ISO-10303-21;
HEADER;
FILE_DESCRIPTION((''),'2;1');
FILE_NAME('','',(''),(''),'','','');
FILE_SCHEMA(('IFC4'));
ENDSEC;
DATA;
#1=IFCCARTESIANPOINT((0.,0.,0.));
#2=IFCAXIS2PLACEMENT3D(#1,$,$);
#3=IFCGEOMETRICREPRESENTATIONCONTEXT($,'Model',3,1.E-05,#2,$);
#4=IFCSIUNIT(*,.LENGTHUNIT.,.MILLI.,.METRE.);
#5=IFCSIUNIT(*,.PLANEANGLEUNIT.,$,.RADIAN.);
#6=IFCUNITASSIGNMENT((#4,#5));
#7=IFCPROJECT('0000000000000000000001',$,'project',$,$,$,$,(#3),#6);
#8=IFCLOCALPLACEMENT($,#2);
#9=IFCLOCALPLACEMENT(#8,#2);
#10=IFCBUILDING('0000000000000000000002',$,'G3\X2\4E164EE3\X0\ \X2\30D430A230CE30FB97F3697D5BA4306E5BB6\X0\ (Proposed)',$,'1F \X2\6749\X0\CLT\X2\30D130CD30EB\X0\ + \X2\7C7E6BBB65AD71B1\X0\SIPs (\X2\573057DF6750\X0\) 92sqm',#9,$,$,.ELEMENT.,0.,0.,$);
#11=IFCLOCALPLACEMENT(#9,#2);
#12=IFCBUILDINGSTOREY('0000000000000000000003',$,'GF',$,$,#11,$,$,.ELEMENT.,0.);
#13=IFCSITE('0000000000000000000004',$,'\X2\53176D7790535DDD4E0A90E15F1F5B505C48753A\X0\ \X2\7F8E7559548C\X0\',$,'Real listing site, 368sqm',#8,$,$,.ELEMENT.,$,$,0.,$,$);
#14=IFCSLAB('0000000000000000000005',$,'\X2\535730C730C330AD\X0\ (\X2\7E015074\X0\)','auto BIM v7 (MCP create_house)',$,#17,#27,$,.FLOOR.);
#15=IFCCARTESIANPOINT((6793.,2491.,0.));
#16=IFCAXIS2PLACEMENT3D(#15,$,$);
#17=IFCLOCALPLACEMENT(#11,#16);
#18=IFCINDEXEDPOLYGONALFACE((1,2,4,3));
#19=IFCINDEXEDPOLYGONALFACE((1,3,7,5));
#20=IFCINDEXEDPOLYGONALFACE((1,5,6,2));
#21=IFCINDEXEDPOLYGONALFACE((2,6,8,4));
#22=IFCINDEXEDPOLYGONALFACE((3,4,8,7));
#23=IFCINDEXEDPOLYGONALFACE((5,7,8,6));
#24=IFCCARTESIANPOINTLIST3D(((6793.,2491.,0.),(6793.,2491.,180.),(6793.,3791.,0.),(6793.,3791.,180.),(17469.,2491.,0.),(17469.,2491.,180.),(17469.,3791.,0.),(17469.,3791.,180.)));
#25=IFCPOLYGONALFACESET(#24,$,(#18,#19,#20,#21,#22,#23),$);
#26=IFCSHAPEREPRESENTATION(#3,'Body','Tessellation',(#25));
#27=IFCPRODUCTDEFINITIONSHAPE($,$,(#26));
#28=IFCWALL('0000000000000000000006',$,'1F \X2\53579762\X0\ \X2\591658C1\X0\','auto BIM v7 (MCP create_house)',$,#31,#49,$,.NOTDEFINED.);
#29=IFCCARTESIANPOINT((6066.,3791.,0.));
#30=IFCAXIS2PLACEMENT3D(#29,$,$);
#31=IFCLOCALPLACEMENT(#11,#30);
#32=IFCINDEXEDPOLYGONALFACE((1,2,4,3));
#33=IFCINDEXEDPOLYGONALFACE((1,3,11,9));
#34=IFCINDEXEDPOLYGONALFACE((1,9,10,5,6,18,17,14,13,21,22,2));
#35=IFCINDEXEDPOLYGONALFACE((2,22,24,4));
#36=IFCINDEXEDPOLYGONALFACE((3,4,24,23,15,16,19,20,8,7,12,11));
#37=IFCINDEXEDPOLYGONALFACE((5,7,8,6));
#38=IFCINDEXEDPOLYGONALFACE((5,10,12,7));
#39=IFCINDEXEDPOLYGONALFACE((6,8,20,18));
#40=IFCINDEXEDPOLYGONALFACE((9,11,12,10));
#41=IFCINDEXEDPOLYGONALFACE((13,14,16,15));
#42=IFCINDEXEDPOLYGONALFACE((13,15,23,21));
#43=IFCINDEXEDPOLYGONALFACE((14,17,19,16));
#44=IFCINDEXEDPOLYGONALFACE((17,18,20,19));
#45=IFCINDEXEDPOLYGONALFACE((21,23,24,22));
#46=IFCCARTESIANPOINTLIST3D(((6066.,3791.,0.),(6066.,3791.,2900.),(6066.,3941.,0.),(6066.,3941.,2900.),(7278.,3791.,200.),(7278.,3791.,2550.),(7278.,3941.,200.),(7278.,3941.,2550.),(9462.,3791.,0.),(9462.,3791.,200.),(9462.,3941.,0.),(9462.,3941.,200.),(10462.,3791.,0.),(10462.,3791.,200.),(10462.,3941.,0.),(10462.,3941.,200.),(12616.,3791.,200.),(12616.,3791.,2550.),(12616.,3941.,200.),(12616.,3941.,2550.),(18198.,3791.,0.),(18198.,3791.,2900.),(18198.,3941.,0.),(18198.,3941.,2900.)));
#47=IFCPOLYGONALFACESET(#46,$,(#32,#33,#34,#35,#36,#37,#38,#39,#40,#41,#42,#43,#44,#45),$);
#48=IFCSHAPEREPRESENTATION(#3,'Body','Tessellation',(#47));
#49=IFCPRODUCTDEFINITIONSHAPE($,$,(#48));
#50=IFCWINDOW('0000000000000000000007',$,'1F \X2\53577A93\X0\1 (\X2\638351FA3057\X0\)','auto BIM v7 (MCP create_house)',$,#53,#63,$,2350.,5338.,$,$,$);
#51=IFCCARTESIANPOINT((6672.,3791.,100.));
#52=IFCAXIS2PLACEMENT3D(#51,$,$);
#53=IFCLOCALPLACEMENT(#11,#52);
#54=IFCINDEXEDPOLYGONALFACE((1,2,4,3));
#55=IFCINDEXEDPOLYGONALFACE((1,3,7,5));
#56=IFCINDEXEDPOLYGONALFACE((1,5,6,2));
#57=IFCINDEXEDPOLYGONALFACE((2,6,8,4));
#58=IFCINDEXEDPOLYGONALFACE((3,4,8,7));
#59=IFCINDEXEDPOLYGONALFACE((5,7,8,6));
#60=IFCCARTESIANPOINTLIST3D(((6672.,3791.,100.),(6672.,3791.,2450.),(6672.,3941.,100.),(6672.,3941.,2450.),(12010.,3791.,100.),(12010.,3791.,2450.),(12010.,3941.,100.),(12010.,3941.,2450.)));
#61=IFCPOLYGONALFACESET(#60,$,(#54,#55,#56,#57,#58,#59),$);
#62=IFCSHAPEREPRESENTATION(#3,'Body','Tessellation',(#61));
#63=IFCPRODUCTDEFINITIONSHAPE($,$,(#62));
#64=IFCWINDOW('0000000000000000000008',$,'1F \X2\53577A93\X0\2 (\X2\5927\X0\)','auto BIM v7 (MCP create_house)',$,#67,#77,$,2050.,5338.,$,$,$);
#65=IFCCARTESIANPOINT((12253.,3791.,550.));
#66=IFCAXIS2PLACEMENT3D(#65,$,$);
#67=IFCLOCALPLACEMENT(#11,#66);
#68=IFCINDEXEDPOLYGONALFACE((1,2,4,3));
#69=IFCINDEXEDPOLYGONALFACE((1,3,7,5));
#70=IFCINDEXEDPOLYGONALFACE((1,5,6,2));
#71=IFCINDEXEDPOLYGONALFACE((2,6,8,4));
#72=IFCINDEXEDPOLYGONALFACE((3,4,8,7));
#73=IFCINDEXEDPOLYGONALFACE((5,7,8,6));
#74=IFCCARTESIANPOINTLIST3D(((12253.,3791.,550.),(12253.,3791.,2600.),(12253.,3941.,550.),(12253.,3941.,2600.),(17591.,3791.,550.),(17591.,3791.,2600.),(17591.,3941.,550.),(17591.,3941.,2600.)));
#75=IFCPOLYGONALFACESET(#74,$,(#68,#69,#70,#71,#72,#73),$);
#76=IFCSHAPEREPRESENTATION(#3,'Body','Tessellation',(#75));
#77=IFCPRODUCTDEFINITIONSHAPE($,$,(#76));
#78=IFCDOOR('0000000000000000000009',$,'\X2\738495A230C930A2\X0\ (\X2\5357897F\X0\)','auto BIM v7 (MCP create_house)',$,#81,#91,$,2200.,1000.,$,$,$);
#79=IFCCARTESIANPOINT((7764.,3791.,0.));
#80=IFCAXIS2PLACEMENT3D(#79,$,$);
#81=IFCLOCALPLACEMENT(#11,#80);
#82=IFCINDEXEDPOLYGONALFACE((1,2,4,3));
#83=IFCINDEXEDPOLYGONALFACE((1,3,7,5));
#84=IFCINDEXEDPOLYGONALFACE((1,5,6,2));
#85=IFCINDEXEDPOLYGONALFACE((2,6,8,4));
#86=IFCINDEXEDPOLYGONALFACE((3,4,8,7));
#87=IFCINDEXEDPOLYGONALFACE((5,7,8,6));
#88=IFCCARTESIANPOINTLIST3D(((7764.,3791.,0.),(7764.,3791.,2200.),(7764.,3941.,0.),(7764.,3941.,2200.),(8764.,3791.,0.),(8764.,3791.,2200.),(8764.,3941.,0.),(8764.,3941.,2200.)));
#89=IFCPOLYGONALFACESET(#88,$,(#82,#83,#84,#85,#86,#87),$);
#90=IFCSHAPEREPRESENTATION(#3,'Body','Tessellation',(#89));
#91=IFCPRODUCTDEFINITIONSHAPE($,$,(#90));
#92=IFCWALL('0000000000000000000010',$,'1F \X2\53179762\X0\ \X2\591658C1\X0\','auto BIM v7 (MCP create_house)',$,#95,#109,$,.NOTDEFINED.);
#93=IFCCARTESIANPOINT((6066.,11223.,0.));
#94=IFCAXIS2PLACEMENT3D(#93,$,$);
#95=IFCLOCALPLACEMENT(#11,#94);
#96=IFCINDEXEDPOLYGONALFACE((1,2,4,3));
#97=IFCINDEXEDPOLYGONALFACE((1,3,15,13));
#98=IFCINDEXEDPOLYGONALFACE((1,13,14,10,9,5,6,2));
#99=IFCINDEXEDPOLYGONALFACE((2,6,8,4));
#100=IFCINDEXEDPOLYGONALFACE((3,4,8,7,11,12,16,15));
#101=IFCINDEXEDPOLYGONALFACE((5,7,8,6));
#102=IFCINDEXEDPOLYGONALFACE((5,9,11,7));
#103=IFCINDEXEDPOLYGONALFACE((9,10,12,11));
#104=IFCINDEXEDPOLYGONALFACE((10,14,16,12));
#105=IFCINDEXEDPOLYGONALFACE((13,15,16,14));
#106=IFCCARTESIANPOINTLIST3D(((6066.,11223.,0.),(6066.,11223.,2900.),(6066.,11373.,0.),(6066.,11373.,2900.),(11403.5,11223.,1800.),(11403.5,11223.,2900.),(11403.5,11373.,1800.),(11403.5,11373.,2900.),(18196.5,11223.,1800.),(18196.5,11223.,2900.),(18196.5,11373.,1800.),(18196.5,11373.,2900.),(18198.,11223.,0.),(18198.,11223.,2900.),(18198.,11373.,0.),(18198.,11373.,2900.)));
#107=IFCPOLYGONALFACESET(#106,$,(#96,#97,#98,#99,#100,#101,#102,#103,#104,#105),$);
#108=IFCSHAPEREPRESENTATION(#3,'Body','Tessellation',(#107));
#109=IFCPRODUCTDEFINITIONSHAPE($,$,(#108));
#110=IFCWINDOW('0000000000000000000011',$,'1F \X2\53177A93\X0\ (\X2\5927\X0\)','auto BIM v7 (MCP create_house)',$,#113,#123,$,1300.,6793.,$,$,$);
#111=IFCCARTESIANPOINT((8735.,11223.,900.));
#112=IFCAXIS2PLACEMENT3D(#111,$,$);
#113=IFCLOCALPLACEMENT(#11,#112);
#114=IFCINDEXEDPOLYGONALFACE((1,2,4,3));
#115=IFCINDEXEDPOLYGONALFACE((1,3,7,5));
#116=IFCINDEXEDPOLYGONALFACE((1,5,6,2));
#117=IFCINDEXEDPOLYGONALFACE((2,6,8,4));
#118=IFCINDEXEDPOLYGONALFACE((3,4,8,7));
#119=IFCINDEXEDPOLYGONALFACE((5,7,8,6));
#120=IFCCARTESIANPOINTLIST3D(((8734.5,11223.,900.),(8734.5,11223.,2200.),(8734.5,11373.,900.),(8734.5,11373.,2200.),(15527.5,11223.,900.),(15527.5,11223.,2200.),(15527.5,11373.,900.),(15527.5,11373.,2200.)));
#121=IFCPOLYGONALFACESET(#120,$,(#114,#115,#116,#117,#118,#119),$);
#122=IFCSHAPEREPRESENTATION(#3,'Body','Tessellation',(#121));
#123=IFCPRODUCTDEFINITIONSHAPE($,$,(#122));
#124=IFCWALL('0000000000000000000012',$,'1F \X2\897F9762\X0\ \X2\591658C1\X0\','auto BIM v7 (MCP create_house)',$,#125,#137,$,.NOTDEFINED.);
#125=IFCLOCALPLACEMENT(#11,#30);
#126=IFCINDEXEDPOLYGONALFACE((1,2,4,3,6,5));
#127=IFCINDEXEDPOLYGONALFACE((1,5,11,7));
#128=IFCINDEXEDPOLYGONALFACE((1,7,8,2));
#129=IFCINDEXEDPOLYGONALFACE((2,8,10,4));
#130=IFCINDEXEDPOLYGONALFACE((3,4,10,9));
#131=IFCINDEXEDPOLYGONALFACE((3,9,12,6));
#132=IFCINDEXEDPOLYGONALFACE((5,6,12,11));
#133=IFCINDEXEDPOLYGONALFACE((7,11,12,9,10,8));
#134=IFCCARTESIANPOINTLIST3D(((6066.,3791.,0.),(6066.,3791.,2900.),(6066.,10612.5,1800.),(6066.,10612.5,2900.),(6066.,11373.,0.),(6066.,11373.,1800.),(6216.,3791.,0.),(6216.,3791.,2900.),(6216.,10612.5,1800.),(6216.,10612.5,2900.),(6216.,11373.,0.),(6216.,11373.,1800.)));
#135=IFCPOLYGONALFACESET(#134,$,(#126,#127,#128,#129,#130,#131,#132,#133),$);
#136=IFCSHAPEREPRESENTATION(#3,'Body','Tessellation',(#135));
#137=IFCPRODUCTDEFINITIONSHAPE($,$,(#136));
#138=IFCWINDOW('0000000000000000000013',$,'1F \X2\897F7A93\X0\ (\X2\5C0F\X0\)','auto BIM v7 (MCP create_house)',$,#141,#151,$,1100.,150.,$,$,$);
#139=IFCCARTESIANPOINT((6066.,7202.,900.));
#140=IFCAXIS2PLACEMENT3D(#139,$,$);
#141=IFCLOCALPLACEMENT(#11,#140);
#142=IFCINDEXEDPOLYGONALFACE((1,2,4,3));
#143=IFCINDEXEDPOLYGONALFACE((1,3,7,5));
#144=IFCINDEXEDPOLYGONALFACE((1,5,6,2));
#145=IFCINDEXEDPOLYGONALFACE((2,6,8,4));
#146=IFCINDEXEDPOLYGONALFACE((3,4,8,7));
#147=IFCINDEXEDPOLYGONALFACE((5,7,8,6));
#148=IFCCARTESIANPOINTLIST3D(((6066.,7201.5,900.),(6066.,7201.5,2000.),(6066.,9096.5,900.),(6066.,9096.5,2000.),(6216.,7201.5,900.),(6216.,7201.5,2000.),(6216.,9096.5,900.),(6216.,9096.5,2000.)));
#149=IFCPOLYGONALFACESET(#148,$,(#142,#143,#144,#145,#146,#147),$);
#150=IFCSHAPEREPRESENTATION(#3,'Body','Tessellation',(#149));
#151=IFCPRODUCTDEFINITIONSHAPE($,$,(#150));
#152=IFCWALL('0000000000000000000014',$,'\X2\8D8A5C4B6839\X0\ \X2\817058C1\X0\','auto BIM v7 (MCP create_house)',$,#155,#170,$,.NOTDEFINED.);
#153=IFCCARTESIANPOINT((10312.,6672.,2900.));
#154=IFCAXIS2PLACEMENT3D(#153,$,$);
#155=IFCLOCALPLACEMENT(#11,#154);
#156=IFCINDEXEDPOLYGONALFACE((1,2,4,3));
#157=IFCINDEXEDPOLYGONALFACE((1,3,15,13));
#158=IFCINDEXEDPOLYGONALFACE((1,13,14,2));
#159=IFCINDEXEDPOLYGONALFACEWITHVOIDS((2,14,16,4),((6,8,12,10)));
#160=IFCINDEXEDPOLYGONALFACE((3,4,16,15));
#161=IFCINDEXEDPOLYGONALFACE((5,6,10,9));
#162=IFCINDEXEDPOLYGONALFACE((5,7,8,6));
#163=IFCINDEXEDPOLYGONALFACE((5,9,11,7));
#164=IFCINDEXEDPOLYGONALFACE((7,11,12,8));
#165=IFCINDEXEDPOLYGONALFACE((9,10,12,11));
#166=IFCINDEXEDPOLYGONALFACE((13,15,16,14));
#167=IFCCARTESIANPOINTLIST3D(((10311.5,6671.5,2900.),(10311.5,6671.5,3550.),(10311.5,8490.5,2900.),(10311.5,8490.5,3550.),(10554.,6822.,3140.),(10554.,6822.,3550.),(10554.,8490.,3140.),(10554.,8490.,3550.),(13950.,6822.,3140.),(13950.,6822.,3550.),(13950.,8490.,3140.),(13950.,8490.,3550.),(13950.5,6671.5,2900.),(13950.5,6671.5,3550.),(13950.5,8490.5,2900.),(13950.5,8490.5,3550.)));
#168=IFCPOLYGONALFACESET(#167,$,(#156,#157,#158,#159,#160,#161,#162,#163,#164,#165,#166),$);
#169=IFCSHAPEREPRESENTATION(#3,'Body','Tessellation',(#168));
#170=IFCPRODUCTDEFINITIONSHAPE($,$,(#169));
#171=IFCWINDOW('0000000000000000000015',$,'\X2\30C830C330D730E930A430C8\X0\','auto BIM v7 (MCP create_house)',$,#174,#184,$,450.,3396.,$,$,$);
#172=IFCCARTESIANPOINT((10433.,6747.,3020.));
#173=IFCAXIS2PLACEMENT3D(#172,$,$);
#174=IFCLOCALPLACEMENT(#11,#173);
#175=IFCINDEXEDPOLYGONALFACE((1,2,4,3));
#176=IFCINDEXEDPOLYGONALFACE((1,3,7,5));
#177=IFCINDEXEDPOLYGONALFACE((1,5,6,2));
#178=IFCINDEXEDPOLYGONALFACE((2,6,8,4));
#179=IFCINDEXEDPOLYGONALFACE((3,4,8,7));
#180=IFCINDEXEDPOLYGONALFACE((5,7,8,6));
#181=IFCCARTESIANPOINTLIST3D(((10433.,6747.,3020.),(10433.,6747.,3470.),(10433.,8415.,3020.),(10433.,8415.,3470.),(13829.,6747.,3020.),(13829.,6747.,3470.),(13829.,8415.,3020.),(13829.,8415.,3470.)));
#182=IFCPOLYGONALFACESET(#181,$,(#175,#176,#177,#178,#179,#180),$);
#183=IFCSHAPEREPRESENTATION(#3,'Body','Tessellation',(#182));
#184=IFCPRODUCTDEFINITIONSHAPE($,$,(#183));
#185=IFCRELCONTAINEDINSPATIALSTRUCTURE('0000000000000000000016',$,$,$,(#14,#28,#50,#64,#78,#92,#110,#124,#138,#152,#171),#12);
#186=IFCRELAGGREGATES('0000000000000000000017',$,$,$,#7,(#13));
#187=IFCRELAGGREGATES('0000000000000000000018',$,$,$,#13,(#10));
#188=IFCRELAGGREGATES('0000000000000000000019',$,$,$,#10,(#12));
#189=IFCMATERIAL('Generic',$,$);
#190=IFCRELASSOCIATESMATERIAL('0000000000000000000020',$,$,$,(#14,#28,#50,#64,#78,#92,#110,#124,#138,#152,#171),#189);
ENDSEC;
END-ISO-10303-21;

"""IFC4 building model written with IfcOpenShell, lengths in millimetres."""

from ifc_helpers import new_model, si_unit, frame, frame_2d, origin, place, context, project, spatial, rectangle, extrude, material, element, fill, save


model = new_model("IFC4")

# Units and contexts
model_context = context("Model", 3, precision=1e-05, world=origin())
ifc_project = project(units=[si_unit("LENGTHUNIT", "METRE", prefix="MILLI"), si_unit("PLANEANGLEUNIT", "RADIAN")], contexts=[model_context])

# Site, building, storey
site_placement = place(None, origin())
site = spatial("IfcSite", under=ifc_project, at=site_placement, Name="北海道川上郡弟子屈町 美留和", ObjectType="Real listing site, 368sqm", CompositionType="ELEMENT", RefElevation=0.0)
building_placement = place(site_placement, origin())
building = spatial("IfcBuilding", under=site, at=building_placement, Name="G3世代 ピアノ・音楽室の家 (Proposed)", ObjectType="1F 杉CLTパネル + 籾殻断熱SIPs (地域材) 92sqm", CompositionType="ELEMENT", ElevationOfRefHeight=0.0, ElevationOfTerrain=0.0)
storey_placement = place(building_placement, origin())
storey = spatial("IfcBuildingStorey", under=building, at=storey_placement, Name="GF", CompositionType="ELEMENT", Elevation=0.0)

# Slab
ifc_material = material(Name="Generic")
slab_1_placement = place(storey_placement, frame((6793.0, 2491.0, 0.0)))
element("IfcSlab", 1, at=slab_1_placement, inside=storey, material=ifc_material, Name="南デッキ (縁側)", Description="auto BIM v7 (MCP create_house)", PredefinedType="FLOOR", context=model_context, shape_type="SweptSolid", body=[
    extrude(rectangle(XDim=10676.0, YDim=1300.0, at=frame_2d((5338.0, 650.0))), frame((6793.0, 2491.0, 0.0)), (0.0, 0.0, 1.0), 180.0),
])

# Wall, openings, windows, door
wall_1_placement = place(storey_placement, frame((6066.0, 3791.0, 0.0)))
wall_1 = element("IfcWall", 2, at=wall_1_placement, inside=storey, material=ifc_material, Name="1F 南面 外壁", Description="auto BIM v7 (MCP create_house)", PredefinedType="NOTDEFINED", context=model_context, shape_type="SweptSolid", body=[
    extrude(rectangle(XDim=12132.0, YDim=150.0, at=frame_2d((6066.0, 75.0))), frame((6066.0, 3791.0, 0.0)), (0.0, 0.0, 1.0), 2900.0),
])
opening_1_placement = place(storey_placement, frame((6672.0, 3791.0, 100.0)))
opening_1 = element("IfcOpeningElement", 3, at=opening_1_placement, cuts=wall_1, PredefinedType="NOTDEFINED", context=model_context, shape_type="SweptSolid", body=[
    extrude(rectangle(XDim=5338.0, YDim=150.0, at=frame_2d((2669.0, 75.0))), frame((6672.0, 3791.0, 100.0)), (0.0, 0.0, 1.0), 2350.0),
])
opening_2_placement = place(storey_placement, frame((12253.0, 3791.0, 550.0)))
opening_2 = element("IfcOpeningElement", 4, at=opening_2_placement, cuts=wall_1, PredefinedType="NOTDEFINED", context=model_context, shape_type="SweptSolid", body=[
    extrude(rectangle(XDim=5338.0, YDim=150.0, at=frame_2d((2669.0, 75.0))), frame((12253.0, 3791.0, 550.0)), (0.0, 0.0, 1.0), 2050.0),
])
opening_3_placement = place(storey_placement, frame((7764.0, 3791.0, 0.0)))
opening_3 = element("IfcOpeningElement", 5, at=opening_3_placement, cuts=wall_1, PredefinedType="NOTDEFINED", context=model_context, shape_type="SweptSolid", body=[
    extrude(rectangle(XDim=1000.0, YDim=150.0, at=frame_2d((500.0, 75.0))), frame((7764.0, 3791.0, 0.0)), (0.0, 0.0, 1.0), 2200.0),
])
window_1_placement = place(storey_placement, frame((6672.0, 3791.0, 100.0)))
window_1 = element("IfcWindow", 6, at=window_1_placement, inside=storey, material=ifc_material, Name="1F 南窓1 (掃出し)", Description="auto BIM v7 (MCP create_house)", OverallHeight=2350.0, OverallWidth=5338.0, context=model_context, shape_type="SweptSolid", body=[
    extrude(rectangle(XDim=5338.0, YDim=150.0, at=frame_2d((2669.0, 75.0))), frame((6672.0, 3791.0, 100.0)), (0.0, 0.0, 1.0), 2350.0),
])
fill(opening_1, window_1)
window_2_placement = place(storey_placement, frame((12253.0, 3791.0, 550.0)))
window_2 = element("IfcWindow", 7, at=window_2_placement, inside=storey, material=ifc_material, Name="1F 南窓2 (大)", Description="auto BIM v7 (MCP create_house)", OverallHeight=2050.0, OverallWidth=5338.0, context=model_context, shape_type="SweptSolid", body=[
    extrude(rectangle(XDim=5338.0, YDim=150.0, at=frame_2d((2669.0, 75.0))), frame((12253.0, 3791.0, 550.0)), (0.0, 0.0, 1.0), 2050.0),
])
fill(opening_2, window_2)
door_placement = place(storey_placement, frame((7764.0, 3791.0, 0.0)))
door = element("IfcDoor", 8, at=door_placement, inside=storey, material=ifc_material, Name="玄関ドア (南西)", Description="auto BIM v7 (MCP create_house)", OverallHeight=2200.0, OverallWidth=1000.0, context=model_context, shape_type="SweptSolid", body=[
    extrude(rectangle(XDim=1000.0, YDim=150.0, at=frame_2d((500.0, 75.0))), frame((7764.0, 3791.0, 0.0)), (0.0, 0.0, 1.0), 2200.0),
])
fill(opening_3, door)

# Walls, openings, windows
wall_2_placement = place(storey_placement, frame((6066.0, 11223.0, 0.0)))
wall_2 = element("IfcWall", 9, at=wall_2_placement, inside=storey, material=ifc_material, Name="1F 北面 外壁", Description="auto BIM v7 (MCP create_house)", PredefinedType="NOTDEFINED", context=model_context, shape_type="SweptSolid", body=[
    extrude(rectangle(XDim=12132.0, YDim=150.0, at=frame_2d((6066.0, 75.0))), frame((6066.0, 11223.0, 0.0)), (0.0, 0.0, 1.0), 2900.0),
])
opening_4_placement = place(storey_placement, frame((8735.0, 11223.0, 900.0)))
opening_4 = element("IfcOpeningElement", 10, at=opening_4_placement, cuts=wall_2, PredefinedType="NOTDEFINED", context=model_context, shape_type="SweptSolid", body=[
    extrude(rectangle(XDim=6793.0, YDim=150.0, at=frame_2d((3396.0, 75.0))), frame((8735.0, 11223.0, 900.0)), (0.0, 0.0, 1.0), 1300.0),
])
window_3_placement = place(storey_placement, frame((8735.0, 11223.0, 900.0)))
window_3 = element("IfcWindow", 11, at=window_3_placement, inside=storey, material=ifc_material, Name="1F 北窓 (大)", Description="auto BIM v7 (MCP create_house)", OverallHeight=1300.0, OverallWidth=6793.0, context=model_context, shape_type="SweptSolid", body=[
    extrude(rectangle(XDim=6793.0, YDim=150.0, at=frame_2d((3396.0, 75.0))), frame((8735.0, 11223.0, 900.0)), (0.0, 0.0, 1.0), 1300.0),
])
fill(opening_4, window_3)
wall_3_placement = place(storey_placement, frame((6066.0, 3791.0, 0.0)))
wall_3 = element("IfcWall", 12, at=wall_3_placement, inside=storey, material=ifc_material, Name="1F 西面 外壁", Description="auto BIM v7 (MCP create_house)", PredefinedType="NOTDEFINED", context=model_context, shape_type="SweptSolid", body=[
    extrude(rectangle(XDim=150.0, YDim=7582.0, at=frame_2d((75.0, 3791.0))), frame((6066.0, 3791.0, 0.0)), (0.0, 0.0, 1.0), 2900.0),
])
opening_5_placement = place(storey_placement, frame((6066.0, 7202.0, 900.0)))
opening_5 = element("IfcOpeningElement", 13, at=opening_5_placement, cuts=wall_3, PredefinedType="NOTDEFINED", context=model_context, shape_type="SweptSolid", body=[
    extrude(rectangle(XDim=150.0, YDim=1895.0, at=frame_2d((75.0, 947.0))), frame((6066.0, 7202.0, 900.0)), (0.0, 0.0, 1.0), 1100.0),
])
window_4_placement = place(storey_placement, frame((6066.0, 7202.0, 900.0)))
window_4 = element("IfcWindow", 14, at=window_4_placement, inside=storey, material=ifc_material, Name="1F 西窓 (小)", Description="auto BIM v7 (MCP create_house)", OverallHeight=1100.0, OverallWidth=150.0, context=model_context, shape_type="SweptSolid", body=[
    extrude(rectangle(XDim=150.0, YDim=1895.0, at=frame_2d((75.0, 947.0))), frame((6066.0, 7202.0, 900.0)), (0.0, 0.0, 1.0), 1100.0),
])
fill(opening_5, window_4)

# Wall, opening, window
wall_4_placement = place(storey_placement, frame((10312.0, 6672.0, 2900.0)))
wall_4 = element("IfcWall", 15, at=wall_4_placement, inside=storey, material=ifc_material, Name="越屋根 腰壁", Description="auto BIM v7 (MCP create_house)", PredefinedType="NOTDEFINED", context=model_context, shape_type="SweptSolid", body=[
    extrude(rectangle(XDim=3639.0, YDim=1819.0, at=frame_2d((1819.0, 909.0))), frame((10312.0, 6672.0, 2900.0)), (0.0, 0.0, 1.0), 650.0),
])
opening_6_placement = place(storey_placement, frame((10433.0, 6747.0, 3020.0)))
opening_6 = element("IfcOpeningElement", 16, at=opening_6_placement, cuts=wall_4, PredefinedType="NOTDEFINED", context=model_context, shape_type="SweptSolid", body=[
    extrude(rectangle(XDim=3396.0, YDim=1668.0, at=frame_2d((1698.0, 834.0))), frame((10433.0, 6747.0, 3020.0)), (0.0, 0.0, 1.0), 450.0),
])
window_5_placement = place(storey_placement, frame((10433.0, 6747.0, 3020.0)))
window_5 = element("IfcWindow", 17, at=window_5_placement, inside=storey, material=ifc_material, Name="トップライト", Description="auto BIM v7 (MCP create_house)", OverallHeight=450.0, OverallWidth=3396.0, context=model_context, shape_type="SweptSolid", body=[
    extrude(rectangle(XDim=3396.0, YDim=1668.0, at=frame_2d((1698.0, 834.0))), frame((10433.0, 6747.0, 3020.0)), (0.0, 0.0, 1.0), 450.0),
])
fill(opening_6, window_5)

save(model, "model.ifc")
